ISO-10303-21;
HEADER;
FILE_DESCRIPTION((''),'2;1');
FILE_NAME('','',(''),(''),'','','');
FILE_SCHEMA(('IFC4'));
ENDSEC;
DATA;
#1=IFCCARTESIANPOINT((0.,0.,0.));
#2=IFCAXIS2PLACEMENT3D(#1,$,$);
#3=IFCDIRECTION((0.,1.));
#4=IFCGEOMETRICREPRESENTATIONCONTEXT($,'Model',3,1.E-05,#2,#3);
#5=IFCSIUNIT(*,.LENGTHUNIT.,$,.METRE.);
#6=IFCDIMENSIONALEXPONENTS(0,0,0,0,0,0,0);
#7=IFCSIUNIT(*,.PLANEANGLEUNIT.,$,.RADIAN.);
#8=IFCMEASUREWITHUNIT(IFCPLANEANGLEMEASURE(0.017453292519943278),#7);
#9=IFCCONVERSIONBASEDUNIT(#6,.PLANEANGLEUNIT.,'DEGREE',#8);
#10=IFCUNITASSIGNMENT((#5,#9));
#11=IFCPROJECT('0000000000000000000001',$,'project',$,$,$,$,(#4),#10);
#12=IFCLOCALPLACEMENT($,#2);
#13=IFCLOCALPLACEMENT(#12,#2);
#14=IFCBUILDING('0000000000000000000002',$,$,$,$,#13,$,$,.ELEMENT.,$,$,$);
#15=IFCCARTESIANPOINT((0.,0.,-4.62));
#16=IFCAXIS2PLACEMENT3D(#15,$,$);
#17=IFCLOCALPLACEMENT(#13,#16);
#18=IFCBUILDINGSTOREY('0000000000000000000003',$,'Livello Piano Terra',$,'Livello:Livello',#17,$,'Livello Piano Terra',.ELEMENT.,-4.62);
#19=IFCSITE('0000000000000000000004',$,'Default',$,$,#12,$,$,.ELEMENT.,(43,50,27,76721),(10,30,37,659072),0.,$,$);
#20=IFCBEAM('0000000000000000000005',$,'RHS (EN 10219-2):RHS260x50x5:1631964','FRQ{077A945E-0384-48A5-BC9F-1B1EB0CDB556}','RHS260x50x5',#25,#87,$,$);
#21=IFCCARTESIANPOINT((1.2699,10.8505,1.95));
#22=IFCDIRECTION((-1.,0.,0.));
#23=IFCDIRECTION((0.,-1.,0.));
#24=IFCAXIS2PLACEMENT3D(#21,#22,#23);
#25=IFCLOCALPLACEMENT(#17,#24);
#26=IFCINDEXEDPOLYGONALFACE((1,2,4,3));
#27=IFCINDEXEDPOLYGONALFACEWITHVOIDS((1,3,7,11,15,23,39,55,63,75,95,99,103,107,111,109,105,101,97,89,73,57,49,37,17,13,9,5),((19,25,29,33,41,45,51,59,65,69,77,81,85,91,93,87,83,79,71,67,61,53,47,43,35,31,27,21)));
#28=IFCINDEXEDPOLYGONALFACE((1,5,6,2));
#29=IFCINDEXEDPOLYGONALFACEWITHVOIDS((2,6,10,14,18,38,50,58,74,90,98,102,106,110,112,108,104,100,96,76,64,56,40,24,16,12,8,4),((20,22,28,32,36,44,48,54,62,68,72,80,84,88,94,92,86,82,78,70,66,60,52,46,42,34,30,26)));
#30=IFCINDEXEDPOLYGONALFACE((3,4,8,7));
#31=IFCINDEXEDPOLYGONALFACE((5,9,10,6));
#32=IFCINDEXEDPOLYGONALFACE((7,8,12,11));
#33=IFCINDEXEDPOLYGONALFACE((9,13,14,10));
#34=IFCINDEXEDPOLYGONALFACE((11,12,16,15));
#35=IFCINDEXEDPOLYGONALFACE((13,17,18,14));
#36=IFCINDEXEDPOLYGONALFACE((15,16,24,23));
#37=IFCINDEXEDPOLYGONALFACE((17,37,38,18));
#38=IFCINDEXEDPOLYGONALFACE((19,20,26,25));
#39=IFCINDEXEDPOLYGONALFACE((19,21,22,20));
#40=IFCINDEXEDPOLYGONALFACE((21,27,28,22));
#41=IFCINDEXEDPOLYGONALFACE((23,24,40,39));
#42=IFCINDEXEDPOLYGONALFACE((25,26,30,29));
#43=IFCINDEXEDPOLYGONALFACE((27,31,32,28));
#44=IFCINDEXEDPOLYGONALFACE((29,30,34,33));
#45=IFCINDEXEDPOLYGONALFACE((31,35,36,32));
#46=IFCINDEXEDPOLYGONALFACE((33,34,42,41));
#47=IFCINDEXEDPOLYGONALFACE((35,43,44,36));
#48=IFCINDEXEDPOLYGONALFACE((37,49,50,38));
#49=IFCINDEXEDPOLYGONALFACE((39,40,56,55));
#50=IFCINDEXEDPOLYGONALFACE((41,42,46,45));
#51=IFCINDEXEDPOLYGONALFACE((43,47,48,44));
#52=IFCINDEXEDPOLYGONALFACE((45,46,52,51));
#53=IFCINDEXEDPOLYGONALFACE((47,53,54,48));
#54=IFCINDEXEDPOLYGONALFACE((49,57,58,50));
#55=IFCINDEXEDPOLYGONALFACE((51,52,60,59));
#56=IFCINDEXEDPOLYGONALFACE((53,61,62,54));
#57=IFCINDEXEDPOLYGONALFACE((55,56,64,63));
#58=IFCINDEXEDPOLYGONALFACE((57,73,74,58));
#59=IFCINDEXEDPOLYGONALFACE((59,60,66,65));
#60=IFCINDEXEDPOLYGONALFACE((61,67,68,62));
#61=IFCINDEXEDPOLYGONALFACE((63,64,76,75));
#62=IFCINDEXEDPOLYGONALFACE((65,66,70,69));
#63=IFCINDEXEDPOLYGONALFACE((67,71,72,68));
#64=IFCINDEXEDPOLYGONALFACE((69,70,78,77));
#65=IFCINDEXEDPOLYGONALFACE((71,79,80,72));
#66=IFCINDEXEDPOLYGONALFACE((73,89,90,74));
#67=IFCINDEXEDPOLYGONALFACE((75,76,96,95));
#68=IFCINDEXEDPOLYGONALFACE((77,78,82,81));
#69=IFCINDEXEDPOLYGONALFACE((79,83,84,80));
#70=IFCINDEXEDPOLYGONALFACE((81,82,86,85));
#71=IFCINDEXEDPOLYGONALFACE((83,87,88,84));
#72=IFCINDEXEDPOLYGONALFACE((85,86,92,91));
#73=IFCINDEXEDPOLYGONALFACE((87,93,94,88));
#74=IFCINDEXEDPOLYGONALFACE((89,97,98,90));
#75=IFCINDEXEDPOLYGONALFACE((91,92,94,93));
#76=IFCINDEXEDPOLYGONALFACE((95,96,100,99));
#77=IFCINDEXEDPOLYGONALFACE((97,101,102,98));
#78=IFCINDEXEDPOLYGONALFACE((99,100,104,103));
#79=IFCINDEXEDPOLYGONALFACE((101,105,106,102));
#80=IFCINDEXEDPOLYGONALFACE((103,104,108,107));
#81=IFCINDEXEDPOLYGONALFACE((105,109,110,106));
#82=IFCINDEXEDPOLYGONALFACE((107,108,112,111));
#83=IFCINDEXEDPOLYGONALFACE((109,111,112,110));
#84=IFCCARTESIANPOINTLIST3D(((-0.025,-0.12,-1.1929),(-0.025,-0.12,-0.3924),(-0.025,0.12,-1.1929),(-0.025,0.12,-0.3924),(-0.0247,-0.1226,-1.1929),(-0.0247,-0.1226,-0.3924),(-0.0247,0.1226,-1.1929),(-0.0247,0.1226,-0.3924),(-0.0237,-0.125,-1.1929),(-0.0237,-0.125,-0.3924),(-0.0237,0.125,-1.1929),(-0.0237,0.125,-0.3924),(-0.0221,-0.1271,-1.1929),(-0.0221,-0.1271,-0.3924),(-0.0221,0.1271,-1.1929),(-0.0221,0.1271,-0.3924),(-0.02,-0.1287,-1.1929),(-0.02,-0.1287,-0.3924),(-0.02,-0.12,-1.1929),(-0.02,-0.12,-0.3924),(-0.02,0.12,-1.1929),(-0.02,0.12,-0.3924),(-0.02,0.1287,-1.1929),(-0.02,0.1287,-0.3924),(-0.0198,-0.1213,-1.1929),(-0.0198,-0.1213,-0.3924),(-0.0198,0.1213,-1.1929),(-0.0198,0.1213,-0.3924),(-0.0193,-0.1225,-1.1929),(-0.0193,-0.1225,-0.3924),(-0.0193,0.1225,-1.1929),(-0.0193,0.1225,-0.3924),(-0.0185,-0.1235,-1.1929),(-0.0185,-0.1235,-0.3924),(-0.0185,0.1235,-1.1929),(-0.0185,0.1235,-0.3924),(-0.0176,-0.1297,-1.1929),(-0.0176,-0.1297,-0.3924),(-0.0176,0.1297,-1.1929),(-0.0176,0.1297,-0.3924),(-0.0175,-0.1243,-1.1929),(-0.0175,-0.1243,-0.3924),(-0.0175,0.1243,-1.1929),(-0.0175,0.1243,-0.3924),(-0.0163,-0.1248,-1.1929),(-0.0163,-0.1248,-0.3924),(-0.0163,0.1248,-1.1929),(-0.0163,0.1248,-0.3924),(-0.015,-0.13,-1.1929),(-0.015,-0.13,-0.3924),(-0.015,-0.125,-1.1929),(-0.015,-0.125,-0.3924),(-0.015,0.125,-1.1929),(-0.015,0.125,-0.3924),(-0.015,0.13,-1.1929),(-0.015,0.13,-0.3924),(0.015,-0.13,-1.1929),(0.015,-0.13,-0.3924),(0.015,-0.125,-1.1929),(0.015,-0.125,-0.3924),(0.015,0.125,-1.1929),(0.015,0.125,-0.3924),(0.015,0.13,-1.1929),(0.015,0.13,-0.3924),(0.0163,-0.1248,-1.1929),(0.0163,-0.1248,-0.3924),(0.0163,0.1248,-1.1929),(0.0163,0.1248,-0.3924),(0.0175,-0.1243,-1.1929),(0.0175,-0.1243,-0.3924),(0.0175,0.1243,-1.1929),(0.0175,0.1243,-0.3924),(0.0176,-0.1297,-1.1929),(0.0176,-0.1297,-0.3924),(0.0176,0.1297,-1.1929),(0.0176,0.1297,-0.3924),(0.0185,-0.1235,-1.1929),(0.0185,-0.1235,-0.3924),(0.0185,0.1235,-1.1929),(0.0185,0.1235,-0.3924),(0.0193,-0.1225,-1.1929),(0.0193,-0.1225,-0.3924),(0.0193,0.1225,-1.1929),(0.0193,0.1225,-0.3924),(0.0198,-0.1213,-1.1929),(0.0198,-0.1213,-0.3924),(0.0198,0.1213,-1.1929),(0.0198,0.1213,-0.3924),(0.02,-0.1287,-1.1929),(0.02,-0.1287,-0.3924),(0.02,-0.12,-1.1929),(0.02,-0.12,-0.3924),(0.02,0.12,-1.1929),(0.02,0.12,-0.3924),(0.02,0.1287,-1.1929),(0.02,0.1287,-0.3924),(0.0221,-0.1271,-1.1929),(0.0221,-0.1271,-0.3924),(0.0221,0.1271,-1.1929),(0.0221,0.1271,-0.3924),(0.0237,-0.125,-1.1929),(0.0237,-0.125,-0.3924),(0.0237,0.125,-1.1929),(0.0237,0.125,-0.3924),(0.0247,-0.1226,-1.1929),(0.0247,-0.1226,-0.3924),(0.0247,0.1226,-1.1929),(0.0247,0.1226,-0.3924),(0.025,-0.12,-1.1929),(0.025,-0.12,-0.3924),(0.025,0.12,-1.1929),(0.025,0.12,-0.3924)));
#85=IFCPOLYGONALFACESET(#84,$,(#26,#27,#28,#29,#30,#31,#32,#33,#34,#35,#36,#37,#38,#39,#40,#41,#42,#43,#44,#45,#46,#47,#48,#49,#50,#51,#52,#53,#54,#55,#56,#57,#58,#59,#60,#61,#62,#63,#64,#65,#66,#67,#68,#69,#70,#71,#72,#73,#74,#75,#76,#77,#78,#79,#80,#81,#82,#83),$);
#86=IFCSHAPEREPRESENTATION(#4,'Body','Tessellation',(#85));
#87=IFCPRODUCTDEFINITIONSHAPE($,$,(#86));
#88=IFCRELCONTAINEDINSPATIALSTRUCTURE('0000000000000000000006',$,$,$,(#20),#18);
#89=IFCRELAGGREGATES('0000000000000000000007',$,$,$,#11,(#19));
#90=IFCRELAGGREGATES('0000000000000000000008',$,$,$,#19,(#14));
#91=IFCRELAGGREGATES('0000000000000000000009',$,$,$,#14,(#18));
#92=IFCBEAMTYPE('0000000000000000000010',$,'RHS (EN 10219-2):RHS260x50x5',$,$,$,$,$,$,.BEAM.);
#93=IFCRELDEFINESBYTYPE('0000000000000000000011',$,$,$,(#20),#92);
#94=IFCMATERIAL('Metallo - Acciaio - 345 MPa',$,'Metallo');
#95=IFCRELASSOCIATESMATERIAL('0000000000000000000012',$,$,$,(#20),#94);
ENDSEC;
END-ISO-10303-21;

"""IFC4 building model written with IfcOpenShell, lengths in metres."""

from ifc_helpers import new_model, entity, si_unit, converted_unit, direction, frame, origin, origin_2d, place, context, project, spatial, hollow_rectangle, extrude, clip, halfspace, material, type_object, element, save


model = new_model("IFC4")

# Units and contexts
model_context = context("Model", 3, precision=1e-05, world=origin(), true_north=direction((0.0, 1.0)))
ifc_project = project(units=[si_unit("LENGTHUNIT", "METRE"), converted_unit("PLANEANGLEUNIT", "DEGREE", entity("IfcPlaneAngleMeasure", 0.017453292519943278), si_unit("PLANEANGLEUNIT", "RADIAN"), dimensions=[0, 0, 0, 0, 0, 0, 0])], contexts=[model_context])

# Site, building, storey
site_placement = place(None, origin())
site = spatial("IfcSite", under=ifc_project, at=site_placement, Name="Default", CompositionType="ELEMENT", RefLatitude=(43, 50, 27, 76721), RefLongitude=(10, 30, 37, 659072), RefElevation=0.0)
building_placement = place(site_placement, origin())
building = spatial("IfcBuilding", under=site, at=building_placement, CompositionType="ELEMENT")
storey_placement = place(building_placement, frame((0.0, 0.0, -4.62)))
storey = spatial("IfcBuildingStorey", under=building, at=storey_placement, Name="Livello Piano Terra", ObjectType="Livello:Livello", LongName="Livello Piano Terra", CompositionType="ELEMENT", Elevation=-4.62)

# Beam
ifc_material_1 = material(Name="Metallo - Acciaio - 345 MPa", Category="Metallo")
beam_type_1 = type_object("IfcBeamType", Name="RHS (EN 10219-2):RHS260x50x5", PredefinedType="BEAM")
beam_1_placement = place(storey_placement, frame((1.2699, 10.8505, 1.95), z_axis=(-1.0, 0.0, 0.0), x_axis=(0.0, -1.0, 0.0)))
element("IfcBeam", 1, at=beam_1_placement, inside=storey, type_object=beam_type_1, material=ifc_material_1, Name="RHS (EN 10219-2):RHS260x50x5:1631964", Description="FRQ{077A945E-0384-48A5-BC9F-1B1EB0CDB556}", ObjectType="RHS260x50x5", context=model_context, shape_type="Clipping", body=[
    clip(extrude(hollow_rectangle(XDim=0.05, YDim=0.26, WallThickness=0.005, InnerFilletRadius=0.005, OuterFilletRadius=0.01, at=origin_2d()), origin(), (0.0, 0.0, -1.0), 1.1929), halfspace(frame((10.8538, 2.67, -0.3924), z_axis=(0.0, 0.0, -1.0), x_axis=(-1.0, 0.0, 0.0)), True)),
])

save(model, "model.ifc")
